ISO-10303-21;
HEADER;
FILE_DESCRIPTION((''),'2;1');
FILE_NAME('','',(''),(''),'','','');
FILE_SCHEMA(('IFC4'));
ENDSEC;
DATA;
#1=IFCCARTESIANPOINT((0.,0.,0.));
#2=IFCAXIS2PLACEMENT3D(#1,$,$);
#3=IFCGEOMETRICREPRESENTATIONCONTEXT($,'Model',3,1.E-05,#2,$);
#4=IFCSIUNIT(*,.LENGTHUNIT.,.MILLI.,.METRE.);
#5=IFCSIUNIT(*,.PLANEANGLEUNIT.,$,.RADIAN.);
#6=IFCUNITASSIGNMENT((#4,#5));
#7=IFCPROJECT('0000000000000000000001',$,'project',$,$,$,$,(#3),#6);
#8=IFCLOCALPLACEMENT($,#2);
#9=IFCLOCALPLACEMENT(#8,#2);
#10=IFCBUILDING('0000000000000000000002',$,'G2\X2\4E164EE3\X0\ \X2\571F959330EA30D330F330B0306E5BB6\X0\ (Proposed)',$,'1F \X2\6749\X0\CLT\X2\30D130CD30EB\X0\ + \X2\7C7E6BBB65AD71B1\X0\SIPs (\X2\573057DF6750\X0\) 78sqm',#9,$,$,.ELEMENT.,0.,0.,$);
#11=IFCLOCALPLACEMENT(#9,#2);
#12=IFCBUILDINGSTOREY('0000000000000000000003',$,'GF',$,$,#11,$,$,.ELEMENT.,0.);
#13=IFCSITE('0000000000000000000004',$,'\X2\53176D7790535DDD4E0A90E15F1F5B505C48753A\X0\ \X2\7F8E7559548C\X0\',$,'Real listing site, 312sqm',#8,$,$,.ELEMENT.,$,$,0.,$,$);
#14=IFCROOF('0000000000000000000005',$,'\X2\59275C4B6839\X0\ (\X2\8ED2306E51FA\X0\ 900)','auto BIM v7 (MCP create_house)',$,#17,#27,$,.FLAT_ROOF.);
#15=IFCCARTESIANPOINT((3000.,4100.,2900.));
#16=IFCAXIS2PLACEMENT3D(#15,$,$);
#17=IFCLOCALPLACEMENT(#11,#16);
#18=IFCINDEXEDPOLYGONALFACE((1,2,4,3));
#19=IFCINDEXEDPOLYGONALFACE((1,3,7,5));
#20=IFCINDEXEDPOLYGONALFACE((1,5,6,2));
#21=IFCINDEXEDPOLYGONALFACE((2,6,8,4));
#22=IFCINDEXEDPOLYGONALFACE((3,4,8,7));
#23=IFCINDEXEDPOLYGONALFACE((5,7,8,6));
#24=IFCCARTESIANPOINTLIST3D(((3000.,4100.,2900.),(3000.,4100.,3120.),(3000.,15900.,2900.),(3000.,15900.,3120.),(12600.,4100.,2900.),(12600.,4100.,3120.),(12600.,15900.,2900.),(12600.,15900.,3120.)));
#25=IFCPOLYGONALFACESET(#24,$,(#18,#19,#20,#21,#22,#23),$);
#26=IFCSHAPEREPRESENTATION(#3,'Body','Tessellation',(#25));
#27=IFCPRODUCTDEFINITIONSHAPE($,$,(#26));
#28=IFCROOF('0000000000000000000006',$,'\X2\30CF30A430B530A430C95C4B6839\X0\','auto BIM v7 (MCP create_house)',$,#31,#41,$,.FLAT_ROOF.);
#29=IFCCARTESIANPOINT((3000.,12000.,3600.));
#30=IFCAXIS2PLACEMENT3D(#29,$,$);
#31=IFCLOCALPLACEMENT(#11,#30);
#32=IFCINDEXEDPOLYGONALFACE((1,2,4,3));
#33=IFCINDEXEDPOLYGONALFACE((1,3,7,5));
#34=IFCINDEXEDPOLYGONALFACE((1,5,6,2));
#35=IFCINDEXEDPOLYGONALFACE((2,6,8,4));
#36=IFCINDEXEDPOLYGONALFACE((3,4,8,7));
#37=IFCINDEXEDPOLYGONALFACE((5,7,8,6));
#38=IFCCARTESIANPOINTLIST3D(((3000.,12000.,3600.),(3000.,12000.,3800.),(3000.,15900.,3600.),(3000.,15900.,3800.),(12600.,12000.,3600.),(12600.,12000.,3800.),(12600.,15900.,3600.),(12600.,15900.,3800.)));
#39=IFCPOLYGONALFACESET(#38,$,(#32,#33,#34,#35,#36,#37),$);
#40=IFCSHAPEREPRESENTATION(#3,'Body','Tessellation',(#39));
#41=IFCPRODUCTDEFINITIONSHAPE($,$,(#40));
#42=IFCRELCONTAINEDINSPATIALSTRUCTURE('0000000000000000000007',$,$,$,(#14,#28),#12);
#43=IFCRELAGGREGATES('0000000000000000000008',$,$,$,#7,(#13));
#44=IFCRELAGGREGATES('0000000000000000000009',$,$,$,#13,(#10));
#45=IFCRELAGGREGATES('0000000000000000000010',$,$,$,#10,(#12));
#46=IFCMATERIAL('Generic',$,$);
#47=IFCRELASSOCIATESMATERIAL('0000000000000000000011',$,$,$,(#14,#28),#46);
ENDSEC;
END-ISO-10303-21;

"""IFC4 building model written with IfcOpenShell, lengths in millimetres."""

from ifc_helpers import new_model, si_unit, frame, frame_2d, origin, place, context, project, spatial, rectangle, extrude, material, element, save


model = new_model("IFC4")

# Units and contexts
model_context = context("Model", 3, precision=1e-05, world=origin())
ifc_project = project(units=[si_unit("LENGTHUNIT", "METRE", prefix="MILLI"), si_unit("PLANEANGLEUNIT", "RADIAN")], contexts=[model_context])

# Site, building, storey
site_placement = place(None, origin())
site = spatial("IfcSite", under=ifc_project, at=site_placement, Name="北海道川上郡弟子屈町 美留和", ObjectType="Real listing site, 312sqm", CompositionType="ELEMENT", RefElevation=0.0)
building_placement = place(site_placement, origin())
building = spatial("IfcBuilding", under=site, at=building_placement, Name="G2世代 土間リビングの家 (Proposed)", ObjectType="1F 杉CLTパネル + 籾殻断熱SIPs (地域材) 78sqm", CompositionType="ELEMENT", ElevationOfRefHeight=0.0, ElevationOfTerrain=0.0)
storey_placement = place(building_placement, origin())
storey = spatial("IfcBuildingStorey", under=building, at=storey_placement, Name="GF", CompositionType="ELEMENT", Elevation=0.0)

# Shared definitions
ifc_material = material(Name="Generic")

# Roofs
roof_1_placement = place(storey_placement, frame((3000.0, 4100.0, 2900.0)))
element("IfcRoof", 1, at=roof_1_placement, inside=storey, material=ifc_material, Name="大屋根 (軒の出 900)", Description="auto BIM v7 (MCP create_house)", PredefinedType="FLAT_ROOF", context=model_context, shape_type="SweptSolid", body=[
    extrude(rectangle(XDim=9600.0, YDim=11800.0, at=frame_2d((4800.0, 5900.0))), frame((3000.0, 4100.0, 2900.0)), (0.0, 0.0, 1.0), 220.0),
])
roof_2_placement = place(storey_placement, frame((3000.0, 12000.0, 3600.0)))
element("IfcRoof", 2, at=roof_2_placement, inside=storey, material=ifc_material, Name="ハイサイド屋根", Description="auto BIM v7 (MCP create_house)", PredefinedType="FLAT_ROOF", context=model_context, shape_type="SweptSolid", body=[
    extrude(rectangle(XDim=9600.0, YDim=3900.0, at=frame_2d((4800.0, 1950.0))), frame((3000.0, 12000.0, 3600.0)), (0.0, 0.0, 1.0), 200.0),
])

save(model, "model.ifc")
